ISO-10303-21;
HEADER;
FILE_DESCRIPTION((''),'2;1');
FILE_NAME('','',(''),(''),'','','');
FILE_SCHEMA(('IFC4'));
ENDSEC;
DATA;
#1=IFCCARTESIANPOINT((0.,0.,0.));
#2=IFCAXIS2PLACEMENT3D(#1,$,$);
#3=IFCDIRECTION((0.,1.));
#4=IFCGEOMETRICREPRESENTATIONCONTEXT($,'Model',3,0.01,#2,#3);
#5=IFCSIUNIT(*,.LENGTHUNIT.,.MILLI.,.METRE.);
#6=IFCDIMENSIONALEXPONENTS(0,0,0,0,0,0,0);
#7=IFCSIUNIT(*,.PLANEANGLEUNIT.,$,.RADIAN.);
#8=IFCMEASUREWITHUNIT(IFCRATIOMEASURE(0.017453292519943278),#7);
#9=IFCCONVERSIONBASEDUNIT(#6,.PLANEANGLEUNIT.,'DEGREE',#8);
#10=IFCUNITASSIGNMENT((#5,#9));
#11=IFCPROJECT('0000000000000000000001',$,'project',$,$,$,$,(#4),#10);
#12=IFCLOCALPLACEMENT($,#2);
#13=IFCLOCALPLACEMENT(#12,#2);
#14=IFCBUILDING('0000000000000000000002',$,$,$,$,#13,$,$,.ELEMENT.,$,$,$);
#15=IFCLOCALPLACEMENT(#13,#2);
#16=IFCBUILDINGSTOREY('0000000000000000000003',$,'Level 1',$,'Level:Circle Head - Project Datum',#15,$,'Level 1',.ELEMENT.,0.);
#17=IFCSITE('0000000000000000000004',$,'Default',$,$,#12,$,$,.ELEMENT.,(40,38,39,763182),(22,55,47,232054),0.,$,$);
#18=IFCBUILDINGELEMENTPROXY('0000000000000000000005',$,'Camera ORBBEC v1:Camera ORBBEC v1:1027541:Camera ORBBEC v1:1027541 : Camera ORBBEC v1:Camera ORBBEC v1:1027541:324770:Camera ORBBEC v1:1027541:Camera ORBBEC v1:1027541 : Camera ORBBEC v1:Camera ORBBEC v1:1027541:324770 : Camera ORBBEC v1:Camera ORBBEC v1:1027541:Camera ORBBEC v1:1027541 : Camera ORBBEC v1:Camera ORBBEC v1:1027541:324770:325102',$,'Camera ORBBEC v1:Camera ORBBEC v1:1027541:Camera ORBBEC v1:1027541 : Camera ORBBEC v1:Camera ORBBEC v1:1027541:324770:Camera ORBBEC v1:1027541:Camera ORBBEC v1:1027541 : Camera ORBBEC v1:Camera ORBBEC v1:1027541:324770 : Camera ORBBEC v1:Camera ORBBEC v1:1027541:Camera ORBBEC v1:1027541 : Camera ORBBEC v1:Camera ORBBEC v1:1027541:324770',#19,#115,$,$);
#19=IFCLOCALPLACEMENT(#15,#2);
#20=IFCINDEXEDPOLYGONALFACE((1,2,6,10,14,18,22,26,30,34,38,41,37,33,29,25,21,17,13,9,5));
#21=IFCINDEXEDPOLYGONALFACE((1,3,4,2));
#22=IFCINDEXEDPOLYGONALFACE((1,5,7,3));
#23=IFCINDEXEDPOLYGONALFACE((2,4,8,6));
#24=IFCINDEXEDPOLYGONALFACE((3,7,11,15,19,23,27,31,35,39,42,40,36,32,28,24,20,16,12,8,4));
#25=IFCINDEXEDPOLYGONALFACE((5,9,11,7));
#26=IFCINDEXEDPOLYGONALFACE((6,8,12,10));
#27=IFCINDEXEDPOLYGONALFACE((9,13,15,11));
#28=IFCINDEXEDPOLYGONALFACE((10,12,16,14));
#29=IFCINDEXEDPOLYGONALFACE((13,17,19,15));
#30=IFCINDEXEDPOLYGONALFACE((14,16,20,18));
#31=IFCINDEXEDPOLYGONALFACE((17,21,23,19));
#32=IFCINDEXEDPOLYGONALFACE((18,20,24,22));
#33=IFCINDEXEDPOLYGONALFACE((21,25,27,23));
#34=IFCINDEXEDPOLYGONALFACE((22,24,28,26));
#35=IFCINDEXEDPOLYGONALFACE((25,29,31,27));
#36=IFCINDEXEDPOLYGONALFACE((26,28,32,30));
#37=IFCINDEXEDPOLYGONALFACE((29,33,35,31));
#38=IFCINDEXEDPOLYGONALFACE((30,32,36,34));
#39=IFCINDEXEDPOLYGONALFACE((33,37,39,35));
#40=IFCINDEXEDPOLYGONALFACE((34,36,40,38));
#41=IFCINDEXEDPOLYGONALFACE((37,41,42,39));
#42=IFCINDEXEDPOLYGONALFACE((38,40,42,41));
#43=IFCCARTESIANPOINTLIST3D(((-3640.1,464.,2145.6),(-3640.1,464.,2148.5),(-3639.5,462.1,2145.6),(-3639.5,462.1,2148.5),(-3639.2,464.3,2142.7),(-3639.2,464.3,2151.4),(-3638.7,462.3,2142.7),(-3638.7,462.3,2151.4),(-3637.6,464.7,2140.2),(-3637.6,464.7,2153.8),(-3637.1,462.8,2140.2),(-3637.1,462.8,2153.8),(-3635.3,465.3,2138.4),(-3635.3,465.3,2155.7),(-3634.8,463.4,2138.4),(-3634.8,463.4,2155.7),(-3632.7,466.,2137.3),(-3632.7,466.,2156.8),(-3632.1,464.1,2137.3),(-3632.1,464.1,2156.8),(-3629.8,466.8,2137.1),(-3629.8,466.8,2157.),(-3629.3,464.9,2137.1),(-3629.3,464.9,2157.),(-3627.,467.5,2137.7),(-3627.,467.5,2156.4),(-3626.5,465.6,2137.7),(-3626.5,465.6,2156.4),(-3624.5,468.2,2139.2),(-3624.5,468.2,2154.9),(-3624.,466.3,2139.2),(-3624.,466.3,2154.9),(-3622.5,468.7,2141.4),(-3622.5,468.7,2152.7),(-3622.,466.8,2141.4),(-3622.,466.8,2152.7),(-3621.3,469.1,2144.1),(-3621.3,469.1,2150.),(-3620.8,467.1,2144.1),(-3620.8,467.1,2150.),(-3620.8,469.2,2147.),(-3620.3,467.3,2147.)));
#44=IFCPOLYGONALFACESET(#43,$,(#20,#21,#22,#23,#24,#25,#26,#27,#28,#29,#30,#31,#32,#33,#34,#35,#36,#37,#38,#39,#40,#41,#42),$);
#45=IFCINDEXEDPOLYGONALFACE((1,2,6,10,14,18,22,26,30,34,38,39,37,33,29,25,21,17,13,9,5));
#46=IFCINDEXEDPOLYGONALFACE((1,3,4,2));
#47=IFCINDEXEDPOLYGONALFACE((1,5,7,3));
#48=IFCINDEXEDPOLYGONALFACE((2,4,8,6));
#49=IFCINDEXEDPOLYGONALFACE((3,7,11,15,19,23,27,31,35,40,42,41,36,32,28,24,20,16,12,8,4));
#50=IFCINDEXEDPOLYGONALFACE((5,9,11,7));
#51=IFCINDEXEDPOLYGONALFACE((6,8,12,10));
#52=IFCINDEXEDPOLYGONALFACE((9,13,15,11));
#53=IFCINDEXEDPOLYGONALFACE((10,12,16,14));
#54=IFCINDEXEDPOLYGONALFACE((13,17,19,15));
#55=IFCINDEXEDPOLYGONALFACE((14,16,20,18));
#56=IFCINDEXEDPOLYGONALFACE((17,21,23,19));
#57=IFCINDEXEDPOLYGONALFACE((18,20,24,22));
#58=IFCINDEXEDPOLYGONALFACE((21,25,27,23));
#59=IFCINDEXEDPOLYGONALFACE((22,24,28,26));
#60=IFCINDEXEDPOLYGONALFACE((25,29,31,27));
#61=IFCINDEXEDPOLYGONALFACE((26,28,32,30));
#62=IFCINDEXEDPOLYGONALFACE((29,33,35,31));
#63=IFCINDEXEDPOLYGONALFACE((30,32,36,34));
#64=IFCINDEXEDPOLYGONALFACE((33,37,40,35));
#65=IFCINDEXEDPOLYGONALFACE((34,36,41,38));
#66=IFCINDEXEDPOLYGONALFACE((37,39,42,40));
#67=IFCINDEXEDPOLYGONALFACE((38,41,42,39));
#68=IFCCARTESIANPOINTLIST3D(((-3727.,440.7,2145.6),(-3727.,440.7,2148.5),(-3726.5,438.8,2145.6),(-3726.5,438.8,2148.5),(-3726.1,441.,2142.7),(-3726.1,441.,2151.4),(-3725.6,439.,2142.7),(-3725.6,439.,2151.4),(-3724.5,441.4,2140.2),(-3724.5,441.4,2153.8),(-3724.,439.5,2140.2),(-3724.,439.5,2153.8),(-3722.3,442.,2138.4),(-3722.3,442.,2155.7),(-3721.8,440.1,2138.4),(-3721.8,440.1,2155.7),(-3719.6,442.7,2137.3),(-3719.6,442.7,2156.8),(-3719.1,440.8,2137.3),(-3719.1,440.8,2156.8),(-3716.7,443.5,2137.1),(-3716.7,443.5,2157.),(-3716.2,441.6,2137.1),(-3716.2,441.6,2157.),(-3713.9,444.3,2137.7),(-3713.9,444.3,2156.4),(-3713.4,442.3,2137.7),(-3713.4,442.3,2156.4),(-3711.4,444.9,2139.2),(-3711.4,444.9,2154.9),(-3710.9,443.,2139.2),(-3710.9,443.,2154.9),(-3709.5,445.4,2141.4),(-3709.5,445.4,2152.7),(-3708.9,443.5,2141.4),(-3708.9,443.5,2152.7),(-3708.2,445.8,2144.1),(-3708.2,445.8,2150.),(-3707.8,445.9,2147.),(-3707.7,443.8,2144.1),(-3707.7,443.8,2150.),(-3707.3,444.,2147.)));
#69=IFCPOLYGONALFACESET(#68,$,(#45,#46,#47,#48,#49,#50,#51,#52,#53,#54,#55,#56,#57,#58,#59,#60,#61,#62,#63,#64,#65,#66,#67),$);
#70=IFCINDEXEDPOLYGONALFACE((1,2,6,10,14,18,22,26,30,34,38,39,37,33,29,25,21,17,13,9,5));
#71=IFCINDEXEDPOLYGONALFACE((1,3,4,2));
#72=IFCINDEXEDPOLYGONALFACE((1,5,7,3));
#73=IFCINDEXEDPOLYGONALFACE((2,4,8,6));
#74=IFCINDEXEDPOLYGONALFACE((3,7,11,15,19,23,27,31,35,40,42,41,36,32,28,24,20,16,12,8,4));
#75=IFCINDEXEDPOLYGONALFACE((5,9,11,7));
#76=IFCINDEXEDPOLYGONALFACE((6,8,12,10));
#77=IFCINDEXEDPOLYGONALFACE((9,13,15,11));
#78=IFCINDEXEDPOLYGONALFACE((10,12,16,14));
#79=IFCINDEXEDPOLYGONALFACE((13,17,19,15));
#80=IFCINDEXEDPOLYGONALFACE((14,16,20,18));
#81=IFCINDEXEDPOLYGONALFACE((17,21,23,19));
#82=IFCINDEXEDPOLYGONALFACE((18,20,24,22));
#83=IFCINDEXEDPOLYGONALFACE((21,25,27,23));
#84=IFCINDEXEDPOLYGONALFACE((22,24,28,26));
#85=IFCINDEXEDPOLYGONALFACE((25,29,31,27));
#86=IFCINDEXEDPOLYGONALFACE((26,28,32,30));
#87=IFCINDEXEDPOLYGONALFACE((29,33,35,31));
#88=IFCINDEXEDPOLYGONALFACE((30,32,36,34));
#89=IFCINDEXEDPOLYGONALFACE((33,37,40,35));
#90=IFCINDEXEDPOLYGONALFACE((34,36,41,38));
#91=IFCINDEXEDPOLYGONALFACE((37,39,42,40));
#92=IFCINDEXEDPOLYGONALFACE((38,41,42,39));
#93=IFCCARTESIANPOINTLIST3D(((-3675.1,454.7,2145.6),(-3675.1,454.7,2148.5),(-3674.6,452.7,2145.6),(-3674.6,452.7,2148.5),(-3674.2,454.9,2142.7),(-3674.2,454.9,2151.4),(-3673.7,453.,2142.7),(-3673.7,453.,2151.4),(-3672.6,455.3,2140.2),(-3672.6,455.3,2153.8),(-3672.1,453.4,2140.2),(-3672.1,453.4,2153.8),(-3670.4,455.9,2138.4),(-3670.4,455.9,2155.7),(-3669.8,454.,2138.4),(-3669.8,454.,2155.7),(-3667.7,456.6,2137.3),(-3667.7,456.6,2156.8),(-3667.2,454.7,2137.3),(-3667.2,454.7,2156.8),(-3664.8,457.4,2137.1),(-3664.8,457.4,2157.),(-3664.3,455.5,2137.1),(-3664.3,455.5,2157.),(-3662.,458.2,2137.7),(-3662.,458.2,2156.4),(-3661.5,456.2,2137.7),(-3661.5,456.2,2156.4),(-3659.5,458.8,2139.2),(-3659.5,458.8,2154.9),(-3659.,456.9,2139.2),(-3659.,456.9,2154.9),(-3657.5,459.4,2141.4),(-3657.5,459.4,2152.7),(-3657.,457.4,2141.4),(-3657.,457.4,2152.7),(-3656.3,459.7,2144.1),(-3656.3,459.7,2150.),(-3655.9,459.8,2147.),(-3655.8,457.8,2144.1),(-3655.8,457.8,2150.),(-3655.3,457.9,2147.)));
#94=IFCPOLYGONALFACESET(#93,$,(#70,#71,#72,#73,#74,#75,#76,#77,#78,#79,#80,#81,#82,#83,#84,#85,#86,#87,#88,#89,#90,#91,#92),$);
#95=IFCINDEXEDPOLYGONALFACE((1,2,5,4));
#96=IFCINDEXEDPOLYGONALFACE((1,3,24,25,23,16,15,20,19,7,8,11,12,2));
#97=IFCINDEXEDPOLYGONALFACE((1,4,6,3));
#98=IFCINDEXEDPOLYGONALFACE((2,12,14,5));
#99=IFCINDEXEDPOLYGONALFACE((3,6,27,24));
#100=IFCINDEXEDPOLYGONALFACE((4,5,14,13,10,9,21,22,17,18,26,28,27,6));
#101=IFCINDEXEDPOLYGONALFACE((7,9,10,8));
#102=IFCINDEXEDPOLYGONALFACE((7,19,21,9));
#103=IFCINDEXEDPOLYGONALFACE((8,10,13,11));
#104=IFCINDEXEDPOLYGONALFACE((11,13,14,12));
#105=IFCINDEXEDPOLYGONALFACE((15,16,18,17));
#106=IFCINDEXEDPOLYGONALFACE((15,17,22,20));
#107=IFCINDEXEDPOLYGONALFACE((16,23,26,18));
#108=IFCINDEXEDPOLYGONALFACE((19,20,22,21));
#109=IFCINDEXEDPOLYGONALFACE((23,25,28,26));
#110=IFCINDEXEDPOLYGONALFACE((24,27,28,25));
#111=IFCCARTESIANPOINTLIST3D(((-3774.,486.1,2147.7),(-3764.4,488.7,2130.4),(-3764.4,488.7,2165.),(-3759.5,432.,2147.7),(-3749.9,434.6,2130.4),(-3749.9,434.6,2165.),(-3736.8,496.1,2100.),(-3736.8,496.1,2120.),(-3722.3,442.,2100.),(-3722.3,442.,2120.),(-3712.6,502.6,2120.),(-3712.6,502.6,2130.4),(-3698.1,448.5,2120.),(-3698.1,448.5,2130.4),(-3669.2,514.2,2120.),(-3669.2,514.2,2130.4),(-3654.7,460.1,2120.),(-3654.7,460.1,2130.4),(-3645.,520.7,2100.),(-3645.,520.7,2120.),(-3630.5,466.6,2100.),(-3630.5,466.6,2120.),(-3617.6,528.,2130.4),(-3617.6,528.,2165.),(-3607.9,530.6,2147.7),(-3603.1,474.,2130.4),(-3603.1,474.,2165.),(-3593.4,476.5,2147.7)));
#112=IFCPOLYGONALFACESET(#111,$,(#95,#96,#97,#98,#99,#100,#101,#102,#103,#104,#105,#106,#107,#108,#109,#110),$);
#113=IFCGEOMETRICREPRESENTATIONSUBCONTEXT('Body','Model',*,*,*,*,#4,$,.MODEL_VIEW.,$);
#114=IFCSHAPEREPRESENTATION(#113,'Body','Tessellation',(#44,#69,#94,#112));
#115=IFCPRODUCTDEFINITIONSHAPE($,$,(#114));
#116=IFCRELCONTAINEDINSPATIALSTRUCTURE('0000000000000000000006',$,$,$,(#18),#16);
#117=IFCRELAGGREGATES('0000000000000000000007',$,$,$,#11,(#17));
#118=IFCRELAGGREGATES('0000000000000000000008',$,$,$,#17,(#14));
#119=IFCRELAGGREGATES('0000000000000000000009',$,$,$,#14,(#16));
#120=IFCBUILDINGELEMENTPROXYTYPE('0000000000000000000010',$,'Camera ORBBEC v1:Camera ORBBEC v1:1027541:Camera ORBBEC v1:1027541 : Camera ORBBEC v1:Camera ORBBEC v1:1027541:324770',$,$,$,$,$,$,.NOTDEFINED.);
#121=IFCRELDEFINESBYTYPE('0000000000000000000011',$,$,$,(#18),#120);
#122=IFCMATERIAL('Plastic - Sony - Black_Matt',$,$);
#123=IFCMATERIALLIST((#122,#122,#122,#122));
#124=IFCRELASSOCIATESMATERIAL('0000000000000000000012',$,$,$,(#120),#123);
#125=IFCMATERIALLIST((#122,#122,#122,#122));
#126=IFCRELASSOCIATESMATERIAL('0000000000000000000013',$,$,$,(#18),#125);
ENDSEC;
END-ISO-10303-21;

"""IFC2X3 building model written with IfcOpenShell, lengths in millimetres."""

from ifc_helpers import new_model, entity, si_unit, converted_unit, direction, frame, frame_2d, origin, origin_2d_with_axis, place, context, subcontext, project, spatial, polyline, circle, outline, extrude, source, transform, mapped, material, material_list, type_object, type_shapes, element, save


model = new_model("IFC2X3")

# Units and contexts
model_context = context("Model", 3, precision=0.01, world=origin(), true_north=direction((0.0, 1.0)))
body_context = subcontext(model_context, "Body", "Model", "MODEL_VIEW")
ifc_project = project(units=[si_unit("LENGTHUNIT", "METRE", prefix="MILLI"), converted_unit("PLANEANGLEUNIT", "DEGREE", entity("IfcRatioMeasure", 0.017453292519943278), si_unit("PLANEANGLEUNIT", "RADIAN"), dimensions=[0, 0, 0, 0, 0, 0, 0])], contexts=[model_context])

# Site, building, storey
site_placement = place(None, origin())
site = spatial("IfcSite", under=ifc_project, at=site_placement, Name="Default", CompositionType="ELEMENT", RefLatitude=(40, 38, 39, 763182), RefLongitude=(22, 55, 47, 232054), RefElevation=0.0)
building_placement = place(site_placement, origin())
building = spatial("IfcBuilding", under=site, at=building_placement, CompositionType="ELEMENT")
storey_placement = place(building_placement, origin())
storey = spatial("IfcBuildingStorey", under=building, at=storey_placement, Name="Level 1", ObjectType="Level:Circle Head - Project Datum", LongName="Level 1", CompositionType="ELEMENT", Elevation=0.0)

# Building element proxy
ifc_material_1 = material(Name="Plastic - Sony - Black_Matt")
ifc_material_list_1 = material_list([ifc_material_1, ifc_material_1, ifc_material_1, ifc_material_1])
ifc_material_list_2 = material_list([ifc_material_1, ifc_material_1, ifc_material_1, ifc_material_1])
building_element_proxy_type_1 = type_object("IfcBuildingElementProxyType", Name="Camera ORBBEC v1:Camera ORBBEC v1:1027541:Camera ORBBEC v1:1027541 : Camera ORBBEC v1:Camera ORBBEC v1:1027541:324770", PredefinedType="NOTDEFINED", material=ifc_material_list_2)
shared_shape_1 = source(origin(), body_context, "Body", "SweptSolid", [
    extrude(circle(Radius=10.0, at=frame_2d((0.0, 0.0), x_axis=(1.0, 0.0))), frame((-3630.0, 464.7, 2147.0), z_axis=(-0.258819, 0.965926, 0.0), x_axis=(0.965926, 0.258819, 0.0)), (0.0, 0.0, 1.0), 2.0),
    extrude(circle(Radius=10.0, at=origin_2d_with_axis()), frame((-3716.9, 441.4, 2147.0), z_axis=(-0.258819, 0.965926, 0.0), x_axis=(0.965926, 0.258819, 0.0)), (0.0, 0.0, 1.0), 2.0),
    extrude(circle(Radius=10.0, at=frame_2d((0.0, 0.0), x_axis=(1.0, 0.0))), frame((-3665.0, 455.3, 2147.0), z_axis=(-0.258819, 0.965926, 0.0), x_axis=(0.965926, 0.258819, 0.0)), (0.0, 0.0, 1.0), 2.0),
    extrude(outline(polyline([(8.1, -83.0), (28.1, -83.0), (38.1, -65.7), (11.4, -19.5), (20.3, -14.3), (32.8, -35.9), (50.2, -25.9), (2.7, 56.3), (-14.7, 46.3), (-2.2, 24.7), (-11.1, 19.5), (-37.9, 65.9), (-57.9, 65.9), (-67.9, 48.6), (8.1, -83.0)])), frame((-3676.4, 454.3, 2130.5), z_axis=(-0.258819, 0.965926, 0.0), x_axis=(0.482963, 0.12941, -0.866025)), (0.0, 0.0, 1.0), 56.0),
])
type_shapes(building_element_proxy_type_1, [shared_shape_1])
proxy_1_placement = place(storey_placement, origin())
element("IfcBuildingElementProxy", 1, at=proxy_1_placement, inside=storey, type_object=building_element_proxy_type_1, material=ifc_material_list_1, Name="Camera ORBBEC v1:Camera ORBBEC v1:1027541:Camera ORBBEC v1:1027541 : Camera ORBBEC v1:Camera ORBBEC v1:1027541:324770:Camera ORBBEC v1:1027541:Camera ORBBEC v1:1027541 : Camera ORBBEC v1:Camera ORBBEC v1:1027541:324770 : Camera ORBBEC v1:Camera ORBBEC v1:1027541:Camera ORBBEC v1:1027541 : Camera ORBBEC v1:Camera ORBBEC v1:1027541:324770:325102", ObjectType="Camera ORBBEC v1:Camera ORBBEC v1:1027541:Camera ORBBEC v1:1027541 : Camera ORBBEC v1:Camera ORBBEC v1:1027541:324770:Camera ORBBEC v1:1027541:Camera ORBBEC v1:1027541 : Camera ORBBEC v1:Camera ORBBEC v1:1027541:324770 : Camera ORBBEC v1:Camera ORBBEC v1:1027541:Camera ORBBEC v1:1027541 : Camera ORBBEC v1:Camera ORBBEC v1:1027541:324770", context=body_context, shape_type="MappedRepresentation", body=[
    mapped(shared_shape_1, transform((0.0, 0.0, 0.0), scale=1.0)),
])

save(model, "model.ifc")
